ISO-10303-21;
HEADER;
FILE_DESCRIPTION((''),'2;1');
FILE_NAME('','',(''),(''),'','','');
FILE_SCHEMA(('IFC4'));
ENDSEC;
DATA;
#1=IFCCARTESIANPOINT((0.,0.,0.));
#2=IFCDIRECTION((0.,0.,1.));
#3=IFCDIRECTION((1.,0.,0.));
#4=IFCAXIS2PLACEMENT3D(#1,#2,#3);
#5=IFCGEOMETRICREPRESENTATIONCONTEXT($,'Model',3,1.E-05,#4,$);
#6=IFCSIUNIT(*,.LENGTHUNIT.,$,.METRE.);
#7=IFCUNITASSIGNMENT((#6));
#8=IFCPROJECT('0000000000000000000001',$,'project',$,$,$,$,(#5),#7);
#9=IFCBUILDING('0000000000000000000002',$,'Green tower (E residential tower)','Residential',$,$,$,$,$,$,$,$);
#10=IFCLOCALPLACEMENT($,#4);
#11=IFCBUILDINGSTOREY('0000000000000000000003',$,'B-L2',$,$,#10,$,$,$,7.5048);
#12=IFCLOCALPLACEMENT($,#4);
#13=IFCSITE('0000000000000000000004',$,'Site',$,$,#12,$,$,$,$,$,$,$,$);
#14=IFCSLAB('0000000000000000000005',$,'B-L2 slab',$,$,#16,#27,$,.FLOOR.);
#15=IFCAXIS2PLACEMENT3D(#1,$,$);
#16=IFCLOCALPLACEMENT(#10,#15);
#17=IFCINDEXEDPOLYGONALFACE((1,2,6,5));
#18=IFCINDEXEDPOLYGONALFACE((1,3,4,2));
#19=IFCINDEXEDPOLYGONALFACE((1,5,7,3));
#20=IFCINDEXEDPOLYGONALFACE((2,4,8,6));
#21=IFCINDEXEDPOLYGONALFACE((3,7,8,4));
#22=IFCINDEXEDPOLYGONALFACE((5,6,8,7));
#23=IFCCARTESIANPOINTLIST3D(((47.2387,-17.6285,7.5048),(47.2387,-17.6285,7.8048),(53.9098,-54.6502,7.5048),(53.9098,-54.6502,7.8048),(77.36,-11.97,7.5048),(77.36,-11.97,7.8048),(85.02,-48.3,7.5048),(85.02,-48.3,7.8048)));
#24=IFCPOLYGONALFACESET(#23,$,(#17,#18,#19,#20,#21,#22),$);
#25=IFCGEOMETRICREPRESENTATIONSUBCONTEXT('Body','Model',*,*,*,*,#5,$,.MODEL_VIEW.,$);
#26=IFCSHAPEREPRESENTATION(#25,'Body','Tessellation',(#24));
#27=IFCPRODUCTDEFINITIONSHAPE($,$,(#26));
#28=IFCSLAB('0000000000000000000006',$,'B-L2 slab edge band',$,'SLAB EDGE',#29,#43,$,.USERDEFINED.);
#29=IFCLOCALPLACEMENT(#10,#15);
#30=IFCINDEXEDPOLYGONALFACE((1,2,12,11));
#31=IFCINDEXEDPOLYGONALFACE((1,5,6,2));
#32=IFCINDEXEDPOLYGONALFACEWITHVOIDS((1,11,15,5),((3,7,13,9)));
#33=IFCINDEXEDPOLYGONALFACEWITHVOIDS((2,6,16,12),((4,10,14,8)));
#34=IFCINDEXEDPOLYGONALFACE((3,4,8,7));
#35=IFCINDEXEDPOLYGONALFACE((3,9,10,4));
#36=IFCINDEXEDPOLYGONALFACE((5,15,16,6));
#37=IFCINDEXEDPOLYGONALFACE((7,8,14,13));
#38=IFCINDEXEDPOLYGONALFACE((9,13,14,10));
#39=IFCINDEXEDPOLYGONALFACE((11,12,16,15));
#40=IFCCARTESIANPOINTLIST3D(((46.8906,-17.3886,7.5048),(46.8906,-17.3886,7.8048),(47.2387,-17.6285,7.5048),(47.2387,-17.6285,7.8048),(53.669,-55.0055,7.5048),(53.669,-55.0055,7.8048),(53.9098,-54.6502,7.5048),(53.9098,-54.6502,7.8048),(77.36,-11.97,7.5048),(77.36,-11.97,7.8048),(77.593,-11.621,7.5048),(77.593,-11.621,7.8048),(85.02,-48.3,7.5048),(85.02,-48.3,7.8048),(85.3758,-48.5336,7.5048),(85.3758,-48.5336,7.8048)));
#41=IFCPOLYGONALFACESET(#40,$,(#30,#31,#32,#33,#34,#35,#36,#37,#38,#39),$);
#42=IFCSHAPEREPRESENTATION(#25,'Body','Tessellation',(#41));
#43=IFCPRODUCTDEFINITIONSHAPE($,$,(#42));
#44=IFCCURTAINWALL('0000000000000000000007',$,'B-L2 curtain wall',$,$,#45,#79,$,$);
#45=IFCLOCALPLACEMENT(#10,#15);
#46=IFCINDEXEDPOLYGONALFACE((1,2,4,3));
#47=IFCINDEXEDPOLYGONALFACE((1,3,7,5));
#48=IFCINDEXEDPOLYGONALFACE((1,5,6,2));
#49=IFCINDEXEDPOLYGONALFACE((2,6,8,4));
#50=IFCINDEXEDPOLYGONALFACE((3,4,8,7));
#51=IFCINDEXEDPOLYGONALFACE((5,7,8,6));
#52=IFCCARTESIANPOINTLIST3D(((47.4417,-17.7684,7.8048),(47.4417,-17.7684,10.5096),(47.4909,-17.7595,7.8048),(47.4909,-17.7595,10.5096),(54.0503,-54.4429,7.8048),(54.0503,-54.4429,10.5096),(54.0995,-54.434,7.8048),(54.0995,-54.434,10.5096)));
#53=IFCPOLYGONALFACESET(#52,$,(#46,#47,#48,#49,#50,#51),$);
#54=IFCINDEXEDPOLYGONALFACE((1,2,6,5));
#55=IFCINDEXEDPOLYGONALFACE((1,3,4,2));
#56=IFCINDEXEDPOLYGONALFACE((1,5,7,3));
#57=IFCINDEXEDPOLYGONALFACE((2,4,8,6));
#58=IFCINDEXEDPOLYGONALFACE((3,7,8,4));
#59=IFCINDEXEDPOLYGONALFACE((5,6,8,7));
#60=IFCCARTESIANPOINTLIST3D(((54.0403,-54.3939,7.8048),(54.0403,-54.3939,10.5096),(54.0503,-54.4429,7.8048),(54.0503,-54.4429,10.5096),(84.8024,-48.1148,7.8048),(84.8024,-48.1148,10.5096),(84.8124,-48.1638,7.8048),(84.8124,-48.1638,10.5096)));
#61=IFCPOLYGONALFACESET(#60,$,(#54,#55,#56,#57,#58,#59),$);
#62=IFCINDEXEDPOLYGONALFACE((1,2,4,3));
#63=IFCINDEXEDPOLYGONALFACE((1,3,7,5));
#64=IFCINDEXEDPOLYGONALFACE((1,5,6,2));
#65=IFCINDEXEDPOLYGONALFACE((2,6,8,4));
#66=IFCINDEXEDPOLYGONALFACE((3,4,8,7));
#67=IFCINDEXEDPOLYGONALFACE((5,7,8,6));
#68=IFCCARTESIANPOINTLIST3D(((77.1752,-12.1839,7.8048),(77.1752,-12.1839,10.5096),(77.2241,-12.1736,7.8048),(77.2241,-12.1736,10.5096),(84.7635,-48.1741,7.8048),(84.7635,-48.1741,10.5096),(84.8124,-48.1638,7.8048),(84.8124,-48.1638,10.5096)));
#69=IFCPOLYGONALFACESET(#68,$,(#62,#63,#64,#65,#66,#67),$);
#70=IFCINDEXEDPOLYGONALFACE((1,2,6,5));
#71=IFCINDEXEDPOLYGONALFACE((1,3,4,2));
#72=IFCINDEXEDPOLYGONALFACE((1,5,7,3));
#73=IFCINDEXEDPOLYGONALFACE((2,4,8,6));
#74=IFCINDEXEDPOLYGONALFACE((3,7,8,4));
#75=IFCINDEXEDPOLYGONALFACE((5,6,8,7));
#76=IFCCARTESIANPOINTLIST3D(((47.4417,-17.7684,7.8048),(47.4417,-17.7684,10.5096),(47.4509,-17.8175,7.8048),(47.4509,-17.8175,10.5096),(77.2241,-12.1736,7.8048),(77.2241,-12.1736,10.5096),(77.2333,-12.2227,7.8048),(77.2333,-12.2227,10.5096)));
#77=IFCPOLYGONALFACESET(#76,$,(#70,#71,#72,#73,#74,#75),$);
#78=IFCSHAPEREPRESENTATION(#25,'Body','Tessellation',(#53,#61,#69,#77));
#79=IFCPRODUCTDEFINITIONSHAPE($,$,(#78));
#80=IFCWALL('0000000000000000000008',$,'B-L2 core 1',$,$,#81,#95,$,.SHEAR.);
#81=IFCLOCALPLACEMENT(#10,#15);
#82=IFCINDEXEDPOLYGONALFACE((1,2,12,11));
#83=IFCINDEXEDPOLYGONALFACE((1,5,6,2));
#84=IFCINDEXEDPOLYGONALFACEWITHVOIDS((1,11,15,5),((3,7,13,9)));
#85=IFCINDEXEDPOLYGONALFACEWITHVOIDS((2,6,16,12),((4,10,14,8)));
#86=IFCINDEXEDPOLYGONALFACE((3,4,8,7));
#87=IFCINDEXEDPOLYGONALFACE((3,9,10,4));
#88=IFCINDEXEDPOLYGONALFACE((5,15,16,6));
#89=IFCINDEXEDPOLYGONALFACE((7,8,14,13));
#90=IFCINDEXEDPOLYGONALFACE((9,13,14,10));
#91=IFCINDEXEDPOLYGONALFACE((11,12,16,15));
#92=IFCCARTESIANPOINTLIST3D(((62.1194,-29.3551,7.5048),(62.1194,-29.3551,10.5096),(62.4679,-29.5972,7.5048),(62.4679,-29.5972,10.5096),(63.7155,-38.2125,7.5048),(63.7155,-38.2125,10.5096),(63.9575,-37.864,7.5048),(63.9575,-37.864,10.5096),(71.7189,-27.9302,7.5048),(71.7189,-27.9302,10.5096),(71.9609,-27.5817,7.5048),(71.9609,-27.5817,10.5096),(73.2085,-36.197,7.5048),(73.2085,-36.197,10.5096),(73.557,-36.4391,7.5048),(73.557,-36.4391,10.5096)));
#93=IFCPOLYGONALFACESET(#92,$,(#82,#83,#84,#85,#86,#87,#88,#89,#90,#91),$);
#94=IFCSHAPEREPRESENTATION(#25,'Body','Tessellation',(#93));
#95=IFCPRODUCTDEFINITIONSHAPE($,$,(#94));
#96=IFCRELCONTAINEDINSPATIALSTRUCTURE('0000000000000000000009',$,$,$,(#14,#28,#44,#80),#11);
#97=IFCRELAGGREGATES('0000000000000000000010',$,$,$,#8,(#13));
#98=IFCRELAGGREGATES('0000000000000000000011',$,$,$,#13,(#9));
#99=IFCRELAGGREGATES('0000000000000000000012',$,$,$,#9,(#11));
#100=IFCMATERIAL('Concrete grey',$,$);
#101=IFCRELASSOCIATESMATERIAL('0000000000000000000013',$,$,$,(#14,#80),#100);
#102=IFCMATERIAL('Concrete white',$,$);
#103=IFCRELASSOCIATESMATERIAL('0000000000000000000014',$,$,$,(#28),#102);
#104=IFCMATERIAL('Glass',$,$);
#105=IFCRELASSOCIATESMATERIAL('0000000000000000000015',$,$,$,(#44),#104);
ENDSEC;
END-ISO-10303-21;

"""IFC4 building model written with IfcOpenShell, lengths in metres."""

from ifc_helpers import new_model, si_unit, frame, origin_with_axes, place, context, subcontext, project, spatial, polyline, outline, extrude, material, element, save


model = new_model("IFC4")

# Units and contexts
model_context = context("Model", 3, precision=1e-05, world=origin_with_axes())
body_context = subcontext(model_context, "Body", "Model", "MODEL_VIEW")
ifc_project = project(units=[si_unit("LENGTHUNIT", "METRE")], contexts=[model_context])

# Site, building, storey
site_placement = place(None, origin_with_axes())
site = spatial("IfcSite", under=ifc_project, at=site_placement, Name="Site")
building = spatial("IfcBuilding", under=site, Name="Green tower (E residential tower)", Description="Residential")
storey_placement = place(None, origin_with_axes())
storey = spatial("IfcBuildingStorey", under=building, at=storey_placement, Name="B-L2", Elevation=7.5048)

# Slabs
ifc_material_1 = material(Name="Concrete grey")
slab_1_placement = place(storey_placement, origin_with_axes())
element("IfcSlab", 1, at=slab_1_placement, inside=storey, material=ifc_material_1, Name="B-L2 slab", PredefinedType="FLOOR", context=body_context, shape_type="SweptSolid", body=[
    extrude(outline(polyline([(47.2387, -17.6285), (53.9098, -54.6502), (85.02, -48.3), (77.36, -11.97), (47.2387, -17.6285)])), frame((0.0, 0.0, 7.5048), z_axis=(0.0, 0.0, 1.0), x_axis=(1.0, 0.0, 0.0)), (0.0, 0.0, 1.0), 0.3),
])
ifc_material_2 = material(Name="Concrete white")
slab_2_placement = place(storey_placement, origin_with_axes())
element("IfcSlab", 2, at=slab_2_placement, inside=storey, material=ifc_material_2, Name="B-L2 slab edge band", ObjectType="SLAB EDGE", PredefinedType="USERDEFINED", context=body_context, shape_type="SweptSolid", body=[
    extrude(outline(polyline([(46.8906, -17.3886), (53.669, -55.0055), (85.3758, -48.5336), (77.593, -11.621), (46.8906, -17.3886)]), holes=[polyline([(47.2387, -17.6285), (53.9098, -54.6502), (85.02, -48.3), (77.36, -11.97), (47.2387, -17.6285)])]), frame((0.0, 0.0, 7.5048), z_axis=(0.0, 0.0, 1.0), x_axis=(1.0, 0.0, 0.0)), (0.0, 0.0, 1.0), 0.3),
])

# Curtain wall
ifc_material_3 = material(Name="Glass")
curtain_wall_placement = place(storey_placement, origin_with_axes())
element("IfcCurtainWall", 3, at=curtain_wall_placement, inside=storey, material=ifc_material_3, Name="B-L2 curtain wall", context=body_context, shape_type="SweptSolid", body=[
    extrude(outline(polyline([(47.4417, -17.7684), (54.0503, -54.4429), (54.0995, -54.434), (47.4909, -17.7595), (47.4417, -17.7684)])), frame((0.0, 0.0, 7.8048), z_axis=(0.0, 0.0, 1.0), x_axis=(1.0, 0.0, 0.0)), (0.0, 0.0, 1.0), 2.7048),
    extrude(outline(polyline([(54.0503, -54.4429), (84.8124, -48.1638), (84.8024, -48.1148), (54.0403, -54.3939), (54.0503, -54.4429)])), frame((0.0, 0.0, 7.8048), z_axis=(0.0, 0.0, 1.0), x_axis=(1.0, 0.0, 0.0)), (0.0, 0.0, 1.0), 2.7048),
    extrude(outline(polyline([(84.8124, -48.1638), (77.2241, -12.1736), (77.1752, -12.1839), (84.7635, -48.1741), (84.8124, -48.1638)])), frame((0.0, 0.0, 7.8048), z_axis=(0.0, 0.0, 1.0), x_axis=(1.0, 0.0, 0.0)), (0.0, 0.0, 1.0), 2.7048),
    extrude(outline(polyline([(77.2241, -12.1736), (47.4417, -17.7684), (47.4509, -17.8175), (77.2333, -12.2227), (77.2241, -12.1736)])), frame((0.0, 0.0, 7.8048), z_axis=(0.0, 0.0, 1.0), x_axis=(1.0, 0.0, 0.0)), (0.0, 0.0, 1.0), 2.7048),
])

# Wall
wall_placement = place(storey_placement, origin_with_axes())
element("IfcWall", 4, at=wall_placement, inside=storey, material=ifc_material_1, Name="B-L2 core 1", PredefinedType="SHEAR", context=body_context, shape_type="SweptSolid", body=[
    extrude(outline(polyline([(62.1194, -29.3551), (63.7155, -38.2125), (73.557, -36.4391), (71.9609, -27.5817), (62.1194, -29.3551)]), holes=[polyline([(62.4679, -29.5972), (63.9575, -37.864), (73.2085, -36.197), (71.7189, -27.9302), (62.4679, -29.5972)])]), frame((0.0, 0.0, 7.5048), z_axis=(0.0, 0.0, 1.0), x_axis=(1.0, 0.0, 0.0)), (0.0, 0.0, 1.0), 3.0048),
])

save(model, "model.ifc")
